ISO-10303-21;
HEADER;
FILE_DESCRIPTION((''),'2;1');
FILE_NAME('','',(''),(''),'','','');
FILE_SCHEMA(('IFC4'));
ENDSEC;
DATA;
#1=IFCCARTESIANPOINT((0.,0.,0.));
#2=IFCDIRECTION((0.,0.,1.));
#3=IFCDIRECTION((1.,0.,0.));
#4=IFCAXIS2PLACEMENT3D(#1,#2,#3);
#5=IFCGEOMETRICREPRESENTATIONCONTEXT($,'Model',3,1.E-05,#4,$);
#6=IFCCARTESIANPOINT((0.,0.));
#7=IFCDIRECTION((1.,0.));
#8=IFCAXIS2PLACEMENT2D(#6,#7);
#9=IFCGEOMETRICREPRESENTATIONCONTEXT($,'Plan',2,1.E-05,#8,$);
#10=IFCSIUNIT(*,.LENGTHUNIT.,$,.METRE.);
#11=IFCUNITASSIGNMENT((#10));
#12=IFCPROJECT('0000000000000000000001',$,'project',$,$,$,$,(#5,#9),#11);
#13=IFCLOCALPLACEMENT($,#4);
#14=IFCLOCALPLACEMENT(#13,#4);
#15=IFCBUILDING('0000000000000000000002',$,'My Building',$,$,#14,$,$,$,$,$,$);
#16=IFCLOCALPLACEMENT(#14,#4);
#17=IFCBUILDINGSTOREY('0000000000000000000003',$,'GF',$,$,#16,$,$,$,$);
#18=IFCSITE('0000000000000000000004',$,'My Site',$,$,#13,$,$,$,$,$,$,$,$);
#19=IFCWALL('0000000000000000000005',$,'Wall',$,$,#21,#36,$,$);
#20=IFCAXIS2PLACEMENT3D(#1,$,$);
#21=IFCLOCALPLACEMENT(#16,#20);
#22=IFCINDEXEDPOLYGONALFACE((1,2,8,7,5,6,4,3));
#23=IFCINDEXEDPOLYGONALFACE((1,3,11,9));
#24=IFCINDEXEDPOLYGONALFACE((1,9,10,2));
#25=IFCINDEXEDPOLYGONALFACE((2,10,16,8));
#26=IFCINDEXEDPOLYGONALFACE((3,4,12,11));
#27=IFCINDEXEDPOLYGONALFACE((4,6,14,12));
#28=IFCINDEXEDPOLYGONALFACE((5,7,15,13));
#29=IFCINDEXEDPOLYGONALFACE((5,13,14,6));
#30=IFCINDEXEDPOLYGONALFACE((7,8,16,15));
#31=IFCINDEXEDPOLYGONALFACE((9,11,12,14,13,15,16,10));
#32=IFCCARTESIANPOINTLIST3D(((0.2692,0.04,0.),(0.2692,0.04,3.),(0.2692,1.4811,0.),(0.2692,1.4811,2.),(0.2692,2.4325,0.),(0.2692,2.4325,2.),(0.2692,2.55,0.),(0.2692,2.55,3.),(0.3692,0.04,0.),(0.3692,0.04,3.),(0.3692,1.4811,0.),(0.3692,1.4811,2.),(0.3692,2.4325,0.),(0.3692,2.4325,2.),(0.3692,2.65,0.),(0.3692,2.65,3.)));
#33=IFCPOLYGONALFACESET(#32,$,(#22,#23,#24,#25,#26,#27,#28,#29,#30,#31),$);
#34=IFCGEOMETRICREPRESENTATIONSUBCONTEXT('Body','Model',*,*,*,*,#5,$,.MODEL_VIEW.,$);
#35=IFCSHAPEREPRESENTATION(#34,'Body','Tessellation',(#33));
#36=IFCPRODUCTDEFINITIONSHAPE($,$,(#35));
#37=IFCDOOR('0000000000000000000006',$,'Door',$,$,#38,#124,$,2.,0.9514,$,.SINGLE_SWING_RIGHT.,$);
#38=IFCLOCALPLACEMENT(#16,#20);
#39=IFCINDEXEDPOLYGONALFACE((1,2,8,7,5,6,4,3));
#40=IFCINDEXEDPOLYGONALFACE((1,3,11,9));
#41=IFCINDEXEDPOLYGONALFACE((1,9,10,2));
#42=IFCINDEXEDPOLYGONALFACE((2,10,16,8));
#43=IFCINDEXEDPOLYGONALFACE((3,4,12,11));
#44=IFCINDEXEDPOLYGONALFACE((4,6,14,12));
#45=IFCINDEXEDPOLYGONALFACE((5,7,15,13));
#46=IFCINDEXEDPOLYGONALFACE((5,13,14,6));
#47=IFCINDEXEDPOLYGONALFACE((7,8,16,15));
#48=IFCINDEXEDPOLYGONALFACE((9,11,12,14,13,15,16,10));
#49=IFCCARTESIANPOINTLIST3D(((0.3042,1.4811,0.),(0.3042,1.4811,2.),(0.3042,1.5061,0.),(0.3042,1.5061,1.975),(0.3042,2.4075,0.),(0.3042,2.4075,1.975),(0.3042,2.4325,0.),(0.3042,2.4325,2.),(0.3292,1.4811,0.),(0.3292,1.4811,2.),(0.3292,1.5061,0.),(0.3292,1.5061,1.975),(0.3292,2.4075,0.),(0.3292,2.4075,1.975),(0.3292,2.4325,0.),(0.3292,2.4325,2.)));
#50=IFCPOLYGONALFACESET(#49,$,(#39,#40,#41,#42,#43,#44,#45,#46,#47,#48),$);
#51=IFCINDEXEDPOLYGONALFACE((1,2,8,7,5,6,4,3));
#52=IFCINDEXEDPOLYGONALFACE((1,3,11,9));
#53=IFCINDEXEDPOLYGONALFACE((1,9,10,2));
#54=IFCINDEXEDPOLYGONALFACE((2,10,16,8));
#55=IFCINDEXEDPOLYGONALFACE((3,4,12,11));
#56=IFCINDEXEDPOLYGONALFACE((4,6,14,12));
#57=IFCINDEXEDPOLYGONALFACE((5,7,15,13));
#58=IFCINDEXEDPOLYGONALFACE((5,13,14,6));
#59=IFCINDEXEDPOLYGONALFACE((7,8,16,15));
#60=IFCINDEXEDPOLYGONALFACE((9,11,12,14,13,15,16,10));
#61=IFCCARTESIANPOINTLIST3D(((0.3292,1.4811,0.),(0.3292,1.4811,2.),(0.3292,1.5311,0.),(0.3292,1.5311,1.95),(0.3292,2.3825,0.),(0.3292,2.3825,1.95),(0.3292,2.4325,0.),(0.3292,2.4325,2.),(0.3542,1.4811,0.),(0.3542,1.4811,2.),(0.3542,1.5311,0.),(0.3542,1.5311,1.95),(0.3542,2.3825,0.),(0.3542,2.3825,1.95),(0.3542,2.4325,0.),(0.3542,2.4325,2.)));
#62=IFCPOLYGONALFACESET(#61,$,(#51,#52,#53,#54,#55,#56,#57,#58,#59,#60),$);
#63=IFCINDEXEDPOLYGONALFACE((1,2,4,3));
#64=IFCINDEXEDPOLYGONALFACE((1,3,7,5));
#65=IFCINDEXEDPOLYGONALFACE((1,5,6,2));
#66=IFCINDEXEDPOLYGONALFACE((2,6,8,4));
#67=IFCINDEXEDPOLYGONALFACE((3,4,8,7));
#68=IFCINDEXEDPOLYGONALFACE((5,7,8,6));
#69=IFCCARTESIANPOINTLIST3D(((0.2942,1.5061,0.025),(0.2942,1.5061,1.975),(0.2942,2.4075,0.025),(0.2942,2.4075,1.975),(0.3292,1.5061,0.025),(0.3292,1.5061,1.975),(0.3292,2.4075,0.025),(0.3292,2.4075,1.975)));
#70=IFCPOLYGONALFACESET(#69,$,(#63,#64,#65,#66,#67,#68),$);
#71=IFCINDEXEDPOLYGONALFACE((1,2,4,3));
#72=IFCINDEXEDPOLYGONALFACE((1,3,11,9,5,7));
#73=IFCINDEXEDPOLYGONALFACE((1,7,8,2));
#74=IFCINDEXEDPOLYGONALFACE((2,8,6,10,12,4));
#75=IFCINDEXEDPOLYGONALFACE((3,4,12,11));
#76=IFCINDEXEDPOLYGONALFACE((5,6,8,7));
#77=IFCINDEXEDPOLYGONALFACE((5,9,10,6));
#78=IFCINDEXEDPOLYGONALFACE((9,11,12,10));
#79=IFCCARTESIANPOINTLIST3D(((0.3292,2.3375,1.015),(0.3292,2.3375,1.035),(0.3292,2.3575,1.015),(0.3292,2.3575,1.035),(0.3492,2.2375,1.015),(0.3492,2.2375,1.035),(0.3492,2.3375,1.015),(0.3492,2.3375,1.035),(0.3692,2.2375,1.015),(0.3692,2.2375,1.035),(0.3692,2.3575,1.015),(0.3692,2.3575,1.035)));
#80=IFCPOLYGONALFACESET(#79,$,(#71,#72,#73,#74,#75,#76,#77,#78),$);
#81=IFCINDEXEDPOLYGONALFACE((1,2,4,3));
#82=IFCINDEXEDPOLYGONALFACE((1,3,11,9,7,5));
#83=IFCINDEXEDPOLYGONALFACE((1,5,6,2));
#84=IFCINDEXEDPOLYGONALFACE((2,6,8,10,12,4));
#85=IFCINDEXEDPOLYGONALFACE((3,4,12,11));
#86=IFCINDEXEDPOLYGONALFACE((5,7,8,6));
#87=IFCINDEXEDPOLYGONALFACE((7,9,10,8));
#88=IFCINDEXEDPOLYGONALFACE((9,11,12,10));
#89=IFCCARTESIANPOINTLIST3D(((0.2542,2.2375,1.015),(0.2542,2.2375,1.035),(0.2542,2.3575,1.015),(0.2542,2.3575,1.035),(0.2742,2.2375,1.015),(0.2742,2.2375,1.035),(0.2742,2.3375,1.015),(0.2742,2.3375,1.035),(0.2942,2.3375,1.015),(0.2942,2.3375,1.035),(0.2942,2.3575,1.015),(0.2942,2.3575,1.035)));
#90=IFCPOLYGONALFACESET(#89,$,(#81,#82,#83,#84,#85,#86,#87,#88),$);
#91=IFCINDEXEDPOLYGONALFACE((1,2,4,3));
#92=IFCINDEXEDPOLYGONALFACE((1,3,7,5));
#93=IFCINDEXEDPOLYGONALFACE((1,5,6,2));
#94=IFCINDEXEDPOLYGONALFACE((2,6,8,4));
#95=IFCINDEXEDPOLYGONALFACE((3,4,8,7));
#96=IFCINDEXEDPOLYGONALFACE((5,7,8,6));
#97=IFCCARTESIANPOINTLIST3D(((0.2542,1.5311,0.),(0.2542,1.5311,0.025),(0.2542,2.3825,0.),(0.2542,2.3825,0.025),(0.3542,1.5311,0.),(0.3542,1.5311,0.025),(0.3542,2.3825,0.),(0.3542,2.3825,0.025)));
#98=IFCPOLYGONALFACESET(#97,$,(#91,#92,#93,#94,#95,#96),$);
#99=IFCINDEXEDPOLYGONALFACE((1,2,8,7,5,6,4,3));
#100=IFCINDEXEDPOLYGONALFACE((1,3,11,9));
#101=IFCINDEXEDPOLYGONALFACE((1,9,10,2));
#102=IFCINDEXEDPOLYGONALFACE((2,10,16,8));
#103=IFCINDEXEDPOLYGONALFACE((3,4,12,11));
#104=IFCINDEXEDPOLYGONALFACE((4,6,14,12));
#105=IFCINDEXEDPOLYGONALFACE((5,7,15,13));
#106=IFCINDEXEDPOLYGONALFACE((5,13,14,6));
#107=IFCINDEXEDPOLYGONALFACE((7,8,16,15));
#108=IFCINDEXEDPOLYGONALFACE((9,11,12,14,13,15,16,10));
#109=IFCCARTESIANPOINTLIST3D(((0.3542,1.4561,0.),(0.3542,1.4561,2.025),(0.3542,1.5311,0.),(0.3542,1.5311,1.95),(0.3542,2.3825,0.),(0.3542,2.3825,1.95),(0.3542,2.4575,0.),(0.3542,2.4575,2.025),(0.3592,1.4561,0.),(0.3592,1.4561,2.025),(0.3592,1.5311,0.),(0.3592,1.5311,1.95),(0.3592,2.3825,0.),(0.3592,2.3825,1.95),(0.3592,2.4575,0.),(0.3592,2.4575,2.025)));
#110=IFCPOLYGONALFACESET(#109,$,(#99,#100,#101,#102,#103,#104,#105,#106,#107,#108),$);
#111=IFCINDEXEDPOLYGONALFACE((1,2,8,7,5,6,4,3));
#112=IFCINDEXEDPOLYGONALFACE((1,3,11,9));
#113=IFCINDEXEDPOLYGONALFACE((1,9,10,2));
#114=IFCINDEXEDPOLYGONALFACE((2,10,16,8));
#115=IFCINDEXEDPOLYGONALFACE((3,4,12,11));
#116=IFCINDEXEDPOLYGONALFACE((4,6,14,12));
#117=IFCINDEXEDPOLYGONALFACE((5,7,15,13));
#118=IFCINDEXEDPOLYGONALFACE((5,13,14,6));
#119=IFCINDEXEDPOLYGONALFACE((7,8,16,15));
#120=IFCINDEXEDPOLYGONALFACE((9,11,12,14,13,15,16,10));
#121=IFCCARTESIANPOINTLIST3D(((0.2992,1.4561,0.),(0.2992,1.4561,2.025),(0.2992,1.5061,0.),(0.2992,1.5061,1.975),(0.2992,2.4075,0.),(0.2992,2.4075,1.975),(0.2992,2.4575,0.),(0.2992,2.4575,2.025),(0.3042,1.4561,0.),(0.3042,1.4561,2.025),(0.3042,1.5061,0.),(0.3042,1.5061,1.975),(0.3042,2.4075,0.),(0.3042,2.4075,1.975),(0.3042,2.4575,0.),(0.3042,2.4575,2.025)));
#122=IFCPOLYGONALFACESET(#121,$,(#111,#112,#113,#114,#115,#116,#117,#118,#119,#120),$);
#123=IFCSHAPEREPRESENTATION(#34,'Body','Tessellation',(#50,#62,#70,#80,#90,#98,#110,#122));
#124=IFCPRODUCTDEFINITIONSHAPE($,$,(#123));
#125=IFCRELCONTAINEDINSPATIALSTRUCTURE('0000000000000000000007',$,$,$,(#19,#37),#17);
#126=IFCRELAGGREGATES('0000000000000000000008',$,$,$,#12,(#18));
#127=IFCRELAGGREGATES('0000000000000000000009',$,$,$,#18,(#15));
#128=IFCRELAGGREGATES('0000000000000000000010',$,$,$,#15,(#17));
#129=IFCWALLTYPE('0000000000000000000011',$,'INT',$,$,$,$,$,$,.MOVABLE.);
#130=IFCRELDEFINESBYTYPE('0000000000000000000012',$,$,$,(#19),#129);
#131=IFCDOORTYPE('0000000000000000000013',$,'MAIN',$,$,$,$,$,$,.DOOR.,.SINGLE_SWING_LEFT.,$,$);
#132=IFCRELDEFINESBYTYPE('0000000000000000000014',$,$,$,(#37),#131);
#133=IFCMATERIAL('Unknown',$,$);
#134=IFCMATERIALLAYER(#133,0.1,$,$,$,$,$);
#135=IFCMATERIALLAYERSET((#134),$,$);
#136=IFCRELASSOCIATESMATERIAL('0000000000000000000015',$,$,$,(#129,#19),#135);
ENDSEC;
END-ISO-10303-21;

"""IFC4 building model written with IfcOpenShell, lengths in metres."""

from ifc_helpers import new_model, entity, si_unit, frame, origin_with_axes, origin_2d_with_axis, place, context, subcontext, project, spatial, line, indexed_curve, outline, extrude, shape, source, transform, mapped, material, layer, layer_set, layer_usage, type_object, type_shapes, element, fill, save


model = new_model("IFC4")

# Units and contexts
model_context = context("Model", 3, precision=1e-05, world=origin_with_axes())
plan_context = context("Plan", 2, precision=1e-05, world=origin_2d_with_axis())
body_context_1 = subcontext(model_context, "Body", "Model", "MODEL_VIEW")
body_context_2 = subcontext(plan_context, "Body", "Plan", "PLAN_VIEW")
ifc_project = project(units=[si_unit("LENGTHUNIT", "METRE")], contexts=[model_context, plan_context])

# Site, building, storey
site_placement = place(None, origin_with_axes())
site = spatial("IfcSite", under=ifc_project, at=site_placement, Name="My Site")
building_placement = place(site_placement, origin_with_axes())
building = spatial("IfcBuilding", under=site, at=building_placement, Name="My Building")
storey_placement = place(building_placement, origin_with_axes())
storey = spatial("IfcBuildingStorey", under=building, at=storey_placement, Name="GF")

# Shared definitions
ifc_material = material(Name="Unknown")

# Shared definitions
door_type = type_object("IfcDoorType", Name="MAIN", OperationType="SINGLE_SWING_LEFT", PredefinedType="DOOR")
shared_shape_1 = source(origin_with_axes(), body_context_1, "Body", "SweptSolid", [
    extrude(outline(indexed_curve([(0.0, 0.0), (0.0, 2.0), (0.9514, 2.0), (0.9514, 0.0), (0.9264, 0.0), (0.9264, 1.975), (0.025, 1.975), (0.025, 0.0)], segments=[line(1, 2, 3, 4, 5, 6, 7, 8, 1)])), frame((0.0, 0.025, 0.0), z_axis=(0.0, -1.0, 0.0), x_axis=(1.0, 0.0, 0.0)), (0.0, 0.0, -1.0), 0.025),
    extrude(outline(indexed_curve([(0.0, 0.0), (0.0, 2.0), (0.9514, 2.0), (0.9514, 0.0), (0.9014, 0.0), (0.9014, 1.95), (0.05, 1.95), (0.05, 0.0)], segments=[line(1, 2, 3, 4, 5, 6, 7, 8, 1)])), frame((0.0, 0.0, 0.0), z_axis=(0.0, -1.0, 0.0), x_axis=(1.0, 0.0, 0.0)), (0.0, 0.0, -1.0), 0.025),
    extrude(outline(indexed_curve([(0.0, 0.0), (0.9014, 0.0), (0.9014, 0.035), (0.0, 0.035)], segments=[line(1, 2, 3, 4, 1)])), frame((0.025, 0.025, 0.025), z_axis=(0.0, 0.0, 1.0), x_axis=(1.0, 0.0, 0.0)), (0.0, 0.0, 1.0), 1.95),
    extrude(outline(indexed_curve([(0.0, 0.0), (0.0, -0.04), (-0.12, -0.04), (-0.12, -0.02), (-0.02, -0.02), (-0.02, 0.0)], segments=[line(1, 2, 3, 4, 5, 6, 1)])), frame((0.8764, 0.025, 1.015), z_axis=(0.0, 0.0, 1.0), x_axis=(1.0, 0.0, 0.0)), (0.0, 0.0, 1.0), 0.02),
    extrude(outline(indexed_curve([(0.0, 0.0), (0.0, 0.04), (-0.12, 0.04), (-0.12, 0.02), (-0.02, 0.02), (-0.02, 0.0)], segments=[line(1, 2, 3, 4, 5, 6, 1)])), frame((0.8764, 0.06, 1.015), z_axis=(0.0, 0.0, 1.0), x_axis=(1.0, 0.0, 0.0)), (0.0, 0.0, 1.0), 0.02),
    extrude(outline(indexed_curve([(0.0, 0.0), (0.8514, 0.0), (0.8514, 0.1), (0.0, 0.1)], segments=[line(1, 2, 3, 4, 1)])), frame((0.05, 0.0, 0.0), z_axis=(0.0, 0.0, 1.0), x_axis=(1.0, 0.0, 0.0)), (0.0, 0.0, 1.0), 0.025),
    extrude(outline(indexed_curve([(0.0, 0.0), (0.0, 2.025), (1.0014, 2.025), (1.0014, 0.0), (0.9264, 0.0), (0.9264, 1.95), (0.075, 1.95), (0.075, 0.0)], segments=[line(1, 2, 3, 4, 5, 6, 7, 8, 1)])), frame((-0.025, -0.005, 0.0), z_axis=(0.0, -1.0, 0.0), x_axis=(1.0, 0.0, 0.0)), (0.0, 0.0, -1.0), 0.005),
    extrude(outline(indexed_curve([(0.0, 0.0), (0.0, 2.025), (1.0014, 2.025), (1.0014, 0.0), (0.9514, 0.0), (0.9514, 1.975), (0.05, 1.975), (0.05, 0.0)], segments=[line(1, 2, 3, 4, 5, 6, 7, 8, 1)])), frame((-0.025, 0.05, 0.0), z_axis=(0.0, -1.0, 0.0), x_axis=(1.0, 0.0, 0.0)), (0.0, 0.0, -1.0), 0.005),
])
shared_shape_2 = source(origin_with_axes(), body_context_2, "Body", "Curve2D", [
    entity("IfcIndexedPolyCurve", entity("IfcCartesianPointList2D", [[0.0, 0.0], [0.0, 0.05], [0.025, 0.05], [0.025, 0.025], [0.05, 0.025], [0.05, 0.0]]), [entity("IfcLineIndex", [1, 2, 3, 4, 5, 6, 1])]),
    entity("IfcIndexedPolyCurve", entity("IfcCartesianPointList2D", [[0.9514, 0.0], [0.9514, 0.05], [0.9264, 0.05], [0.9264, 0.025], [0.9014, 0.025], [0.9014, 0.0]]), [entity("IfcLineIndex", [1, 2, 3, 4, 5, 6, 1])]),
    entity("IfcTrimmedCurve", entity("IfcEllipse", entity("IfcAxis2Placement2D", entity("IfcCartesianPoint", [0.06, 0.05]), entity("IfcDirection", [1.0, 0.0])), 0.8664, 0.9014), [entity("IfcCartesianPoint", [0.9264, 0.05])], [entity("IfcCartesianPoint", [0.06, 0.9514])], True, "CARTESIAN"),
    entity("IfcIndexedPolyCurve", entity("IfcCartesianPointList2D", [[0.025, 0.05], [0.06, 0.05], [0.06, 0.9514], [0.025, 0.9514]]), [entity("IfcLineIndex", [1, 2, 3, 4, 1])]),
])
type_shapes(door_type, [shared_shape_1, shared_shape_2])

# Wall, opening, door
ifc_layer_1 = layer(ifc_material, 0.1)
ifc_layer_set_1 = layer_set([ifc_layer_1])
ifc_layer_usage_1 = layer_usage(ifc_layer_set_1, "AXIS2", "POSITIVE", 0.0)
wall_type_1 = type_object("IfcWallType", Name="INT", PredefinedType="MOVABLE", material=ifc_layer_set_1)
wall_1_placement = place(storey_placement, frame((0.3692, 0.04, 0.0), z_axis=(0.0, 0.0, 1.0), x_axis=(0.0, 1.0, 0.0)))
wall_1 = element("IfcWall", 1, at=wall_1_placement, inside=storey, type_object=wall_type_1, material=ifc_layer_usage_1, Name="Wall", context=body_context_1, shape_type="SweptSolid", body=[
    extrude(outline(indexed_curve([(0.0, 0.0), (0.0, 0.1), (2.51, 0.1), (2.61, 0.0)], segments=[line(1, 2, 3, 4, 1)])), origin_with_axes(), (0.0, 0.0, 1.0), 3.0),
])
shared_shape_3 = source(origin_with_axes(), body_context_1, "Body", "SweptSolid", [
    extrude(outline(indexed_curve([(0.0, 0.0), (0.9514, 0.0), (0.9514, 2.0), (0.0, 2.0)], segments=[line(1, 2, 3, 4, 1)])), frame((0.0, -0.6, 0.0), z_axis=(0.0, -1.0, 0.0), x_axis=(1.0, 0.0, 0.0)), (0.0, 0.0, -1.0), 1.2),
])
opening_1_placement = place(wall_1_placement, frame((1.4411, 0.015, 0.0), z_axis=(0.0, 0.0, 1.0), x_axis=(1.0, 0.0, 0.0)))
opening_1 = element("IfcOpeningElement", 2, at=opening_1_placement, cuts=wall_1, PredefinedType="OPENING", context=body_context_1, shape_type="MappedRepresentation", body=[
    mapped(shared_shape_3, transform((0.0, 0.0, 0.0), x_axis=(1.0, 0.0, 0.0), y_axis=(0.0, 1.0, 0.0), z_axis=(0.0, 0.0, 1.0), scale=1.0)),
])
door_1_placement = place(opening_1_placement, frame((0.0, 0.0, 0.0), z_axis=(0.0, 0.0, 1.0), x_axis=(1.0, 0.0, 0.0)))
door_1 = element("IfcDoor", 3, at=door_1_placement, inside=storey, type_object=door_type, Name="Door", OperationType="SINGLE_SWING_RIGHT", OverallHeight=2.0, OverallWidth=0.9514, shapes=[
    shape(body_context_1, "Body", "MappedRepresentation", [mapped(shared_shape_1, transform((0.0, 0.0, 0.0), x_axis=(1.0, 0.0, 0.0), y_axis=(0.0, 1.0, 0.0), z_axis=(0.0, 0.0, 1.0), scale=1.0))]),
    shape(body_context_2, "Body", "MappedRepresentation", [mapped(shared_shape_2, transform((0.0, 0.0, 0.0), x_axis=(1.0, 0.0, 0.0), y_axis=(0.0, 1.0, 0.0), z_axis=(0.0, 0.0, 1.0), scale=1.0))]),
])
fill(opening_1, door_1)

save(model, "model.ifc")
